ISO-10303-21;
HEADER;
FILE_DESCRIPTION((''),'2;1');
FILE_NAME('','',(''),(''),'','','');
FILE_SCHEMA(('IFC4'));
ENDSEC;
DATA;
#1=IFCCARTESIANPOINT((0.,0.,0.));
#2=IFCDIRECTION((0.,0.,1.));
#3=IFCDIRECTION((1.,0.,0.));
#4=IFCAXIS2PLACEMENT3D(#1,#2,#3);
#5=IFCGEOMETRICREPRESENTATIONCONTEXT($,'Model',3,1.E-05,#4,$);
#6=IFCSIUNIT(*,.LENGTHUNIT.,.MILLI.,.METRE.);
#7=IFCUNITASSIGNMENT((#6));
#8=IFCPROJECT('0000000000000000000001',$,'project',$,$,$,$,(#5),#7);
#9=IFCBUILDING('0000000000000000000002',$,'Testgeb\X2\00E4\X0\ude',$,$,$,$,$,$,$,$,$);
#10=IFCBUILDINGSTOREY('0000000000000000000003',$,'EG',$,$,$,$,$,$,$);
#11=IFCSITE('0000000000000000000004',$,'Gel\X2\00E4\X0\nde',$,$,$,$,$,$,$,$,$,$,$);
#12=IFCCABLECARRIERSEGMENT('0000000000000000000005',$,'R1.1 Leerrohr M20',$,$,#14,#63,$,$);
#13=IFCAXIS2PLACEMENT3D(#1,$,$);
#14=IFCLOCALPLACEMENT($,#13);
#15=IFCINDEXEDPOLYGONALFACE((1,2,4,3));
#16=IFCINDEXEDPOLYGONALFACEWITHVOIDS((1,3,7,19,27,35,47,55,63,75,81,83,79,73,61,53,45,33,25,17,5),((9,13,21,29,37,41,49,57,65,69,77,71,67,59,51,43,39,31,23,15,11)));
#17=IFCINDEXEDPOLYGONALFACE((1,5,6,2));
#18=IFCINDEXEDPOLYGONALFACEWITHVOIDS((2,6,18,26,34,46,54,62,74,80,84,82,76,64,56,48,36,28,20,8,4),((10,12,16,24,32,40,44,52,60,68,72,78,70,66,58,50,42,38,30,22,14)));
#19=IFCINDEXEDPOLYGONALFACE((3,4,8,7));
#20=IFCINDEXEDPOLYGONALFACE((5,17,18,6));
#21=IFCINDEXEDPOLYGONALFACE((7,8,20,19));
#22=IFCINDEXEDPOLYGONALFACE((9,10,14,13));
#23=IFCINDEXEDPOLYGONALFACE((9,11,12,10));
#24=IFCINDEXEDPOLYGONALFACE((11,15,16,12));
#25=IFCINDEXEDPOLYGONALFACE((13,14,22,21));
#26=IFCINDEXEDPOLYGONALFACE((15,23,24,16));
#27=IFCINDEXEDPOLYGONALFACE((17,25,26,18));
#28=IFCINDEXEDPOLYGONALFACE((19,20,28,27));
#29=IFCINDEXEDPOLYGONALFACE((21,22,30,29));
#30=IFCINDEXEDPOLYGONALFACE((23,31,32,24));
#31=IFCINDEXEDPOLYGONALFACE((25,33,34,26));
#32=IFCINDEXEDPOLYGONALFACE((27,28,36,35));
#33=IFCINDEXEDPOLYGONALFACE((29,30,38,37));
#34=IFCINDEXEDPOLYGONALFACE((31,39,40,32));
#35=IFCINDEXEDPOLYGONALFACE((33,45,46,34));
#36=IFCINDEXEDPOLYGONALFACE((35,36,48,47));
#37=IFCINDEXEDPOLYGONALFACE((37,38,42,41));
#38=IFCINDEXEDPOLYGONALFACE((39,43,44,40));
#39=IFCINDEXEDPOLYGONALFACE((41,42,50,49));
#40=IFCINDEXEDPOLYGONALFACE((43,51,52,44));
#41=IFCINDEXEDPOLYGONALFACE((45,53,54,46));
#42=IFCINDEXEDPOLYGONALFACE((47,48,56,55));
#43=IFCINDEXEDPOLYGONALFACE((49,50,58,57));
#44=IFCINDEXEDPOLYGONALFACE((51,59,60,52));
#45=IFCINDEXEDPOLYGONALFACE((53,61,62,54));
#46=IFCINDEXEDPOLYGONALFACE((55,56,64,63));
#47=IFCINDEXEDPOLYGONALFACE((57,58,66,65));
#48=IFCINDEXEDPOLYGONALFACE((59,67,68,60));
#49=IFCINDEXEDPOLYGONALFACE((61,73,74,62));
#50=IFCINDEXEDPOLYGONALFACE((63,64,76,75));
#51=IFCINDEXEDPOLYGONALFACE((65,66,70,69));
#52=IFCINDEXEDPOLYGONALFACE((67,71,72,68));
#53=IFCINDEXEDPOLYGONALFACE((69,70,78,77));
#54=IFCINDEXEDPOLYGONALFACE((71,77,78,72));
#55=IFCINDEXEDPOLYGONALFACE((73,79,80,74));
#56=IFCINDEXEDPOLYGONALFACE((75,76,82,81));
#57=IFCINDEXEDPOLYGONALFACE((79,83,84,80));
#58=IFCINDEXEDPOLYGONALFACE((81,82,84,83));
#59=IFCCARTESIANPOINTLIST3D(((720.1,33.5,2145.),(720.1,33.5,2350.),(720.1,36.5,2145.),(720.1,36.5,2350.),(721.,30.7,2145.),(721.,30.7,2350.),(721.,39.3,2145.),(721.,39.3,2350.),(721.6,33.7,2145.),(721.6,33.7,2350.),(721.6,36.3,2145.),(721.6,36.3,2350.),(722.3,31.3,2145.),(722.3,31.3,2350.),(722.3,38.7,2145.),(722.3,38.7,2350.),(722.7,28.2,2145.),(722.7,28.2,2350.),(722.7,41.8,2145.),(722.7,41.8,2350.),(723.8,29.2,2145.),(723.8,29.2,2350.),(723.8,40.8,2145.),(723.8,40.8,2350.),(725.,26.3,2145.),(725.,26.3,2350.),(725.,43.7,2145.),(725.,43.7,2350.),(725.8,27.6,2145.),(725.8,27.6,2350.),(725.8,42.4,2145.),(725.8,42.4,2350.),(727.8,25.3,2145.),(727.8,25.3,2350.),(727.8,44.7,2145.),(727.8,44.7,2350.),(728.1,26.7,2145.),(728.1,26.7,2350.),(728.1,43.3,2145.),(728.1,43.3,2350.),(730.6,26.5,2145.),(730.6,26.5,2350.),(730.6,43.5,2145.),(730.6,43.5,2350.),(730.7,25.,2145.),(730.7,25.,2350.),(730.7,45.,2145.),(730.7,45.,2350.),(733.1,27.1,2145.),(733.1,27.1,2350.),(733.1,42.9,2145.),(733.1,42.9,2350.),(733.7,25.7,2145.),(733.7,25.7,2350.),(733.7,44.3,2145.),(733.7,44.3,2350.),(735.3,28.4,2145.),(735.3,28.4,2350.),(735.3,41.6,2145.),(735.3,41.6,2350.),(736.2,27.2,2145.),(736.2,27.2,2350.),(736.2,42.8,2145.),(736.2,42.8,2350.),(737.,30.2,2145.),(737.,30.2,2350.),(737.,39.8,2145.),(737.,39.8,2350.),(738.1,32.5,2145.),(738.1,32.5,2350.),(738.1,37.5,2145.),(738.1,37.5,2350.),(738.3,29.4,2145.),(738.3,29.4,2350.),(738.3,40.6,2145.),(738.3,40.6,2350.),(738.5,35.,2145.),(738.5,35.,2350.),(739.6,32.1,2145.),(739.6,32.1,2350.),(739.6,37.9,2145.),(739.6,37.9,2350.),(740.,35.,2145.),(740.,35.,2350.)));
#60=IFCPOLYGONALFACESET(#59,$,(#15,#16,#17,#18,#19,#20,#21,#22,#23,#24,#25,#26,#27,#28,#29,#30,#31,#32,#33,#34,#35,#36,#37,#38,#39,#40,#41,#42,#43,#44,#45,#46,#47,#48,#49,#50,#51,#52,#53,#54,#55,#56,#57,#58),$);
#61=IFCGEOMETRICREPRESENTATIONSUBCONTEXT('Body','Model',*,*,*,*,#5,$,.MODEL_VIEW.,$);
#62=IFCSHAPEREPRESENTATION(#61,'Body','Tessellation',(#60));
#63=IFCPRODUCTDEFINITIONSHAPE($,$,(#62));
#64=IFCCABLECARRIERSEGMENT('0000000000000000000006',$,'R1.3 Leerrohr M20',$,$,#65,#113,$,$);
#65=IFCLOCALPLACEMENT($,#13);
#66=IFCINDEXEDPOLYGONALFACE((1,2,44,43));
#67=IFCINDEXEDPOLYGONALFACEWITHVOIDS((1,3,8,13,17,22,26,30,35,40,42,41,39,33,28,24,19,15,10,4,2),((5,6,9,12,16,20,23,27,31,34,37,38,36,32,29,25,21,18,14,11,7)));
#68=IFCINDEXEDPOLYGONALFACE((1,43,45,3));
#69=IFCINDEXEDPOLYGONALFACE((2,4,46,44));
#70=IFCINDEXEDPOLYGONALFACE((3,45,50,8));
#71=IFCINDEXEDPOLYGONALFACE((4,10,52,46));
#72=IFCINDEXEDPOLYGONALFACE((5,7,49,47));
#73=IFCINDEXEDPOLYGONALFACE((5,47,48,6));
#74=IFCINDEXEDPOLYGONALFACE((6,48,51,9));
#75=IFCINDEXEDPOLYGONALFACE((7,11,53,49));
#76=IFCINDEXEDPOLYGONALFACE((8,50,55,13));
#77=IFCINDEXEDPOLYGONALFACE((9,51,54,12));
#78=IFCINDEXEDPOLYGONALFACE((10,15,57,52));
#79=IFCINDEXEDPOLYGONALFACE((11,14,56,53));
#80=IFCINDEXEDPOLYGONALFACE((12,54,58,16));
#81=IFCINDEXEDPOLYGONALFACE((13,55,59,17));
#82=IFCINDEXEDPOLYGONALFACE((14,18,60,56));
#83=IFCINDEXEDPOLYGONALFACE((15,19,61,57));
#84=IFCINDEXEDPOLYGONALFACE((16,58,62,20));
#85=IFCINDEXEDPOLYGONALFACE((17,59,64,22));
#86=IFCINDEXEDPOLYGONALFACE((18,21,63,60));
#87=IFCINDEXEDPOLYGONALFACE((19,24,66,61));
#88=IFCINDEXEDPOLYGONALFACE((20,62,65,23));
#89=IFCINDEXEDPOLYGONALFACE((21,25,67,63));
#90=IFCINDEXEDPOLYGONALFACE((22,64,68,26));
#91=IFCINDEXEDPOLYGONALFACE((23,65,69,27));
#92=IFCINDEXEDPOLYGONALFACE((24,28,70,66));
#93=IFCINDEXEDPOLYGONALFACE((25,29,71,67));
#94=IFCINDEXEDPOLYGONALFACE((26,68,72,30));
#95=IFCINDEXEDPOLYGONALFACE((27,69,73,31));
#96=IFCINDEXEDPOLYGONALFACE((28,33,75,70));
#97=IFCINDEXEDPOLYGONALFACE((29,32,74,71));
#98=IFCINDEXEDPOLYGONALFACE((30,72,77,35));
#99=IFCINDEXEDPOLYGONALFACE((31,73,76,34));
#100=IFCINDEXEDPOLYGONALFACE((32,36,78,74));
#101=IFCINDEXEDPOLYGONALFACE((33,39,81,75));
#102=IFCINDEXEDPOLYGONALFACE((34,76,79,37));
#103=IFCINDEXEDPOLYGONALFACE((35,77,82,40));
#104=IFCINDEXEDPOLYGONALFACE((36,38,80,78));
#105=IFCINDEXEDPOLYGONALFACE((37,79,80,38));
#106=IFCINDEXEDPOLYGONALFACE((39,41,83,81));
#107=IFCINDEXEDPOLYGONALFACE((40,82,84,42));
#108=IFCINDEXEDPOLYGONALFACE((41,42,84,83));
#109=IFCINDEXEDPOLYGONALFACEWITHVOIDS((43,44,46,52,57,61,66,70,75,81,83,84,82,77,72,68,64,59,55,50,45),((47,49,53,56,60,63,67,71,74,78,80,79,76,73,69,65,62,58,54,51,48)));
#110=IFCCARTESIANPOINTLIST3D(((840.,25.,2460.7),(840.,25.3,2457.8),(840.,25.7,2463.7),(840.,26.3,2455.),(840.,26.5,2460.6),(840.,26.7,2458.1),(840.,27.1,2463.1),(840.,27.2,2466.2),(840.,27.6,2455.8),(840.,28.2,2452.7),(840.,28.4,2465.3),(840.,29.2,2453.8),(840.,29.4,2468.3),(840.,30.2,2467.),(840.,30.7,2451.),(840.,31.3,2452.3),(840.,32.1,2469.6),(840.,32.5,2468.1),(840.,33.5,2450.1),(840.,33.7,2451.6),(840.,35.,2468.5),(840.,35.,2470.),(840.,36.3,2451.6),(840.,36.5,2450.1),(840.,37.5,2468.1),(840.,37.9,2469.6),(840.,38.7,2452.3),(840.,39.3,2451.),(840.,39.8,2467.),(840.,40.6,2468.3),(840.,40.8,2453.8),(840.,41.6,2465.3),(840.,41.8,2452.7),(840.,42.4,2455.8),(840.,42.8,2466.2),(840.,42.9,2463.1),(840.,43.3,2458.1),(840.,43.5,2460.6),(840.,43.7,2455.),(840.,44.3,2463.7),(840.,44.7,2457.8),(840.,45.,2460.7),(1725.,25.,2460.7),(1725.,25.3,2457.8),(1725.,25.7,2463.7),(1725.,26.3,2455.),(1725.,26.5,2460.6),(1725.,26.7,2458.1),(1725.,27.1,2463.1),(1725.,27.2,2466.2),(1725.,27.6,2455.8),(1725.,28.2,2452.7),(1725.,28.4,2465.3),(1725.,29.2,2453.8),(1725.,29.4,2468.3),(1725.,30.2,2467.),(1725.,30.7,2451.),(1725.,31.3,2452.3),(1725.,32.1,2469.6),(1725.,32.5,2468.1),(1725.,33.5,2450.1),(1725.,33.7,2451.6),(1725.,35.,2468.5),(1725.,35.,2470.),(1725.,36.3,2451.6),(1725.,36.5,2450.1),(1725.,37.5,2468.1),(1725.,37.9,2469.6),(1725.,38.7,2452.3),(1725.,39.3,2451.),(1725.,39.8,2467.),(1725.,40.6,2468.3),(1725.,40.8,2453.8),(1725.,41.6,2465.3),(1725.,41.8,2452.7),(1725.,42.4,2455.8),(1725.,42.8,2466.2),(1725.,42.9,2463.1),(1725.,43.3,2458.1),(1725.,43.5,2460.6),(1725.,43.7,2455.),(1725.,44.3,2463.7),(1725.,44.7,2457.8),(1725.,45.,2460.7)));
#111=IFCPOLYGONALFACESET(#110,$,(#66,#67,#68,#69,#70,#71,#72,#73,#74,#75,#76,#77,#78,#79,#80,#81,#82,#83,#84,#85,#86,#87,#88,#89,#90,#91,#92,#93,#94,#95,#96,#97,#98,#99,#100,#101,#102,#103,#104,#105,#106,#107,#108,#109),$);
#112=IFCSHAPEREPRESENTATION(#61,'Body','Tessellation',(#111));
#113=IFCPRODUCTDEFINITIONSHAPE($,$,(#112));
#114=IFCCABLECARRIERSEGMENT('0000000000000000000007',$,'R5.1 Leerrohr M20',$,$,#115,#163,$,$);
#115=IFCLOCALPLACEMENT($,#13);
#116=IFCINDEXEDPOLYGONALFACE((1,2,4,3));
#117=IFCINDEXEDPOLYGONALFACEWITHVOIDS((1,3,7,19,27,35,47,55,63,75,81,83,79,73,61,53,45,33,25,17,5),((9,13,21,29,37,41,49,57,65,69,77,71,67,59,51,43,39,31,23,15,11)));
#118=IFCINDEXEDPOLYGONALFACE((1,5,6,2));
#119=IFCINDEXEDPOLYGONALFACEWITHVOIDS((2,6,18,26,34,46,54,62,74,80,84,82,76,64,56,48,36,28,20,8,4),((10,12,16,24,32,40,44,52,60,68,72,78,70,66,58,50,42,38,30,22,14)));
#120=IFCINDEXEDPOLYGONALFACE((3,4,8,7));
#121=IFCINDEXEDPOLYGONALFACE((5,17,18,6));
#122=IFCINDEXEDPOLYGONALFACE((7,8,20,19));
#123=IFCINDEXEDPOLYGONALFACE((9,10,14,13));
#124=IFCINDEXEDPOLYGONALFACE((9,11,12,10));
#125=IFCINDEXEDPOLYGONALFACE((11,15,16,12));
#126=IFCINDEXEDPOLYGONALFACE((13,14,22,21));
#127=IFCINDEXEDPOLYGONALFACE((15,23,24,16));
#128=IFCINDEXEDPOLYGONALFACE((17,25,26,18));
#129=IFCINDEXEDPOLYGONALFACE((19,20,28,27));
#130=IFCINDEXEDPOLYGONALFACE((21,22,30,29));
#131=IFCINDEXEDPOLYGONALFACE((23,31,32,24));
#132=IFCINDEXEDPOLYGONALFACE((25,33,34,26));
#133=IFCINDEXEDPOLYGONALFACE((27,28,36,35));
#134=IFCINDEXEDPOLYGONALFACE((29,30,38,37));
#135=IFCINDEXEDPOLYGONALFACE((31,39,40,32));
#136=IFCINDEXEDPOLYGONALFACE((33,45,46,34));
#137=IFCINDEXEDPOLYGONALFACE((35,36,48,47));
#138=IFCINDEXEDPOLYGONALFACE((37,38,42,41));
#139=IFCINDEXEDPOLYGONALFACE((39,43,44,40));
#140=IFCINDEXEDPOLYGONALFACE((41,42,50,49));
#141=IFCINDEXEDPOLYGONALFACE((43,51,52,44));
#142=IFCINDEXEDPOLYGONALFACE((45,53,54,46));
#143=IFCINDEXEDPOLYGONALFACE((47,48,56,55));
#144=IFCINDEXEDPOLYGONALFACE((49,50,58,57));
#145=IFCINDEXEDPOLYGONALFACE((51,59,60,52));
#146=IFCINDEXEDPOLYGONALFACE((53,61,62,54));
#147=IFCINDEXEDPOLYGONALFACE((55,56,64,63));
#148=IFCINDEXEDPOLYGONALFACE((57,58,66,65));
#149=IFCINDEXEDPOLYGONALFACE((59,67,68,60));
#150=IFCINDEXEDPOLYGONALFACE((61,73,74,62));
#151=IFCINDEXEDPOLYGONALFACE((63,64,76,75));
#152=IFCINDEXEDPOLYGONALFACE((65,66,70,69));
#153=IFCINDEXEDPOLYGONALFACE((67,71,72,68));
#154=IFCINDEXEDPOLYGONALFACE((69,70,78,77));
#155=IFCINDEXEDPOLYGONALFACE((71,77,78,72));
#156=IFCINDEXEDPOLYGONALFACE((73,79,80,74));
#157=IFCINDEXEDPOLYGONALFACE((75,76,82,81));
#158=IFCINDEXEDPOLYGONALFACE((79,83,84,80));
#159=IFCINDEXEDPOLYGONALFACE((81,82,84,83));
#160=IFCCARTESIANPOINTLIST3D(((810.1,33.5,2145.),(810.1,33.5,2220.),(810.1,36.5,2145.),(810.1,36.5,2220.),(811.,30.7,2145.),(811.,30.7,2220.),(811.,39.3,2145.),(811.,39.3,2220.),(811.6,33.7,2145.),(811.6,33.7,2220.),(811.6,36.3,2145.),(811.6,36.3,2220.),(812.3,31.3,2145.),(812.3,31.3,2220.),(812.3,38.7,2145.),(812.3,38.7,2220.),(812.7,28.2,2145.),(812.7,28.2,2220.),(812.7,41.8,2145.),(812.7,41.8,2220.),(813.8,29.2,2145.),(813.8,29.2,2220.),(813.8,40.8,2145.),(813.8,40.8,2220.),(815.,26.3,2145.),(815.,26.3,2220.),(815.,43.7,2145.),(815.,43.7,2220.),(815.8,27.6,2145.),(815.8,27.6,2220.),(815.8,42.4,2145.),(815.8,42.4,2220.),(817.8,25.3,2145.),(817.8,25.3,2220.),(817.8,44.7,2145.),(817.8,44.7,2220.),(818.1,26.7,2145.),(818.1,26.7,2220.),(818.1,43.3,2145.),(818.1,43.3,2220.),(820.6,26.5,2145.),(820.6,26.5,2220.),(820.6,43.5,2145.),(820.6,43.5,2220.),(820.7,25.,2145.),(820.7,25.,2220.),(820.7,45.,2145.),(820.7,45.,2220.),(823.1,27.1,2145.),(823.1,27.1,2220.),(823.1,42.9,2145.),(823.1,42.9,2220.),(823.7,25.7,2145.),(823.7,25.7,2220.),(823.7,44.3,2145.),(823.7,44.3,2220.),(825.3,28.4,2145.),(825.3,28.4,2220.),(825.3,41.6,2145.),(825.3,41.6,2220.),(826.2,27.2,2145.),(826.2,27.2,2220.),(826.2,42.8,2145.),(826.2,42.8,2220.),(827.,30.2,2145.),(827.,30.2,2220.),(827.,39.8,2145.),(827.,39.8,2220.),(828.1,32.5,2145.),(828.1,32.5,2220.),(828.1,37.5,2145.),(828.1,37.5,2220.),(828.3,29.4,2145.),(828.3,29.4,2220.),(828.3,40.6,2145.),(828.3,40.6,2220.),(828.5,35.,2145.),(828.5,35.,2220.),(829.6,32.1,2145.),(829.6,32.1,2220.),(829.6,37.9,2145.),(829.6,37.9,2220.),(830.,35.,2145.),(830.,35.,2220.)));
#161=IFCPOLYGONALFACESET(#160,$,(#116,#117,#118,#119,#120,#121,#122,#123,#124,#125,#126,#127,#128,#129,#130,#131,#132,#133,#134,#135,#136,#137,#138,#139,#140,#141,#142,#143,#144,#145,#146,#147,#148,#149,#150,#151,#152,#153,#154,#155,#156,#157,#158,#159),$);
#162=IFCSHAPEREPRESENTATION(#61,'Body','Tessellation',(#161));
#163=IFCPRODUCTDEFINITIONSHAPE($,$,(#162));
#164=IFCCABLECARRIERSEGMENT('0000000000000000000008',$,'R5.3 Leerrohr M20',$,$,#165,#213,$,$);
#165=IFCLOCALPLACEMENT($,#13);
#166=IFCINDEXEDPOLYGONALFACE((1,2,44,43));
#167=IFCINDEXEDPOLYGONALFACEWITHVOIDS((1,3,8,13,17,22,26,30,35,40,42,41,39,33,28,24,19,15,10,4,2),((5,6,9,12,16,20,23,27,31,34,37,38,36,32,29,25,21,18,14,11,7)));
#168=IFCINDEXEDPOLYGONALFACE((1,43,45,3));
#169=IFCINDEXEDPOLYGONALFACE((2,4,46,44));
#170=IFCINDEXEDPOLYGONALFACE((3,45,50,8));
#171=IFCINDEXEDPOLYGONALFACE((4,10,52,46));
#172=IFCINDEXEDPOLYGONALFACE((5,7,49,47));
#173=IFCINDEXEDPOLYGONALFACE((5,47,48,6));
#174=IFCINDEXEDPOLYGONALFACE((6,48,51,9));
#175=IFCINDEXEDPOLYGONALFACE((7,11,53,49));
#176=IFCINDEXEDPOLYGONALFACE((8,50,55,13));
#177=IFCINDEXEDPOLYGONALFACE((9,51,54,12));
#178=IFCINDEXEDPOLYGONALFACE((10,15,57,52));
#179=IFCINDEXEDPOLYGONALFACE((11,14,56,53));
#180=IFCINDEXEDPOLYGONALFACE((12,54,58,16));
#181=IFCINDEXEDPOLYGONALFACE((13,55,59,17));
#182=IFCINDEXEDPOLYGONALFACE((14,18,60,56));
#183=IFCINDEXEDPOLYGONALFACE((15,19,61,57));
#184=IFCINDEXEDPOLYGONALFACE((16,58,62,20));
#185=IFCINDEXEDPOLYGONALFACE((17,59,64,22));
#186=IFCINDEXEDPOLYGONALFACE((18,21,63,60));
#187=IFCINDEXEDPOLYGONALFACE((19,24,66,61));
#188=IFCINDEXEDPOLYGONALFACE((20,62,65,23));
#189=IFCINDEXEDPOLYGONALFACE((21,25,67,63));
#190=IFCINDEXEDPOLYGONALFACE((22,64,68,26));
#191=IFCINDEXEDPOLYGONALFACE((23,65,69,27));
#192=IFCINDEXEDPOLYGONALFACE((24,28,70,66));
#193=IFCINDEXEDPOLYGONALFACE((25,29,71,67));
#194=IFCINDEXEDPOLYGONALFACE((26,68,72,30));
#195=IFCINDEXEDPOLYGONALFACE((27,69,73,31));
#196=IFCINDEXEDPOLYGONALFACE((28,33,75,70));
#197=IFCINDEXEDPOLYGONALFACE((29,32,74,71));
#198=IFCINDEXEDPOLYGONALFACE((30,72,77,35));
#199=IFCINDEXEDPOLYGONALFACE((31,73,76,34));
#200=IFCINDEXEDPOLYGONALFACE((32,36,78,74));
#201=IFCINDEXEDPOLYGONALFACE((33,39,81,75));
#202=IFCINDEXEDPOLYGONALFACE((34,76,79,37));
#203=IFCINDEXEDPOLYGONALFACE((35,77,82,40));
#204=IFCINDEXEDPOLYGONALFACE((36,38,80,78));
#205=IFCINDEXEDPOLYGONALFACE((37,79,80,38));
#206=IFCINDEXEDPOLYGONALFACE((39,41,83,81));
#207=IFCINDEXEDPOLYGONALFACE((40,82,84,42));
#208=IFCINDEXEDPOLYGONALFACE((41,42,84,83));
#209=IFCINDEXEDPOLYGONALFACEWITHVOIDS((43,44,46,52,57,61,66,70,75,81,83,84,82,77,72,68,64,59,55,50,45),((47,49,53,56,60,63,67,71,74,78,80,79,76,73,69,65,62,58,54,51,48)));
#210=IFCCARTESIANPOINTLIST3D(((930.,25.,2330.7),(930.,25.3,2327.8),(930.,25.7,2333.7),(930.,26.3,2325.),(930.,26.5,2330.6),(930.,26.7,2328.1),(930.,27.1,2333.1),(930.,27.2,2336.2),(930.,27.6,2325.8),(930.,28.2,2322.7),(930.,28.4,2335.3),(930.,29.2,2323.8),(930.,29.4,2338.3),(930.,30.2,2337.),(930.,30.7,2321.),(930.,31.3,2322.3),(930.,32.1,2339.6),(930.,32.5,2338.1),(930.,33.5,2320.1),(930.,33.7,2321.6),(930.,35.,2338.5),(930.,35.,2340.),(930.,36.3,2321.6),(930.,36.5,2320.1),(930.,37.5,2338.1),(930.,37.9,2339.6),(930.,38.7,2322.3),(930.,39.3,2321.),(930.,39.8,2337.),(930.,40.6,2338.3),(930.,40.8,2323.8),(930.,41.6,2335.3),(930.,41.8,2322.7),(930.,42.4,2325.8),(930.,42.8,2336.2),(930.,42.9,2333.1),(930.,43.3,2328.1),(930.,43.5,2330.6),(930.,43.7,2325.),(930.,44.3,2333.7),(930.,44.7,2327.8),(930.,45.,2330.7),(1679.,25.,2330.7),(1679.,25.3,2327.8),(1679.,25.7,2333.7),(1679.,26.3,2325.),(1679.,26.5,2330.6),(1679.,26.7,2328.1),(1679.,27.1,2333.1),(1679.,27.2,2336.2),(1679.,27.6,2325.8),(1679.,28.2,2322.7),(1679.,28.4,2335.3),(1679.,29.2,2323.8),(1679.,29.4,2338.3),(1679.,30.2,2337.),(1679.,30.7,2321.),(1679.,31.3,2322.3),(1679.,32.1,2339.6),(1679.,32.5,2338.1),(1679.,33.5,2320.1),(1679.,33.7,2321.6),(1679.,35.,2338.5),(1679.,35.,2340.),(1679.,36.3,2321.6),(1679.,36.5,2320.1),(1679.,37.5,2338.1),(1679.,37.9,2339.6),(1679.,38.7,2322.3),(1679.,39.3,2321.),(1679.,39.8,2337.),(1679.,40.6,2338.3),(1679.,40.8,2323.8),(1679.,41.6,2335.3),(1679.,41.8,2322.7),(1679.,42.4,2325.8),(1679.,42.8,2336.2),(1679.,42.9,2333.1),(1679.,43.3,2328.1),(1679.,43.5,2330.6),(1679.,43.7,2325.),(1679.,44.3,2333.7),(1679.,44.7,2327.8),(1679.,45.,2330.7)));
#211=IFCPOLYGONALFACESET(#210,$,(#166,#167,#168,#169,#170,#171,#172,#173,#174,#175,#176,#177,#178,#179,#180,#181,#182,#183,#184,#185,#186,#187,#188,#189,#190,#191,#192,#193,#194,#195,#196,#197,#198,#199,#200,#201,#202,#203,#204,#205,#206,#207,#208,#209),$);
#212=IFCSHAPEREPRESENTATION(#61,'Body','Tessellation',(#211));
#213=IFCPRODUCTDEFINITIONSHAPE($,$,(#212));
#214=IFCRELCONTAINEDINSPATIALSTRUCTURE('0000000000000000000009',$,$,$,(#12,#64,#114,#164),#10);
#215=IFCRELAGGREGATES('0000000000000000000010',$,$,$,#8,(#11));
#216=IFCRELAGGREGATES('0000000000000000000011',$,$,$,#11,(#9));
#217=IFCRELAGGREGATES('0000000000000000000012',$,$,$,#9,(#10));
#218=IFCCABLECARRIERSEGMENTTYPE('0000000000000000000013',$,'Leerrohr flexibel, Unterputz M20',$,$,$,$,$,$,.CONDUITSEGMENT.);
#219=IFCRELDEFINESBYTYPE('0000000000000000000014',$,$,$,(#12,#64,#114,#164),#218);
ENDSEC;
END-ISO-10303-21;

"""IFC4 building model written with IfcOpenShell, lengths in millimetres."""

from ifc_helpers import new_model, si_unit, frame, origin_with_axes, place, context, subcontext, project, spatial, hollow_circle, extrude, type_object, element, save


model = new_model("IFC4")

# Units and contexts
model_context = context("Model", 3, precision=1e-05, world=origin_with_axes())
body_context = subcontext(model_context, "Body", "Model", "MODEL_VIEW")
ifc_project = project(units=[si_unit("LENGTHUNIT", "METRE", prefix="MILLI")], contexts=[model_context])

# Site, building, storey
site = spatial("IfcSite", under=ifc_project, Name="Gelände")
building = spatial("IfcBuilding", under=site, Name="Testgebäude")
storey = spatial("IfcBuildingStorey", under=building, Name="EG")

# Cable carrier segments
cable_carrier_segment_type_1 = type_object("IfcCableCarrierSegmentType", Name="Leerrohr flexibel, Unterputz M20", PredefinedType="CONDUITSEGMENT")
cable_carrier_segment_1_placement = place(None, frame((730.0, 35.0, 2145.0), z_axis=(0.0, 0.0, 1.0), x_axis=(1.0, 0.0, 0.0)))
element("IfcCableCarrierSegment", 1, at=cable_carrier_segment_1_placement, inside=storey, type_object=cable_carrier_segment_type_1, Name="R1.1 Leerrohr M20", context=body_context, shape_type="SweptSolid", body=[
    extrude(hollow_circle(Radius=10.0, WallThickness=1.5), None, (0.0, 0.0, 1.0), 205.0),
])
cable_carrier_segment_2_placement = place(None, frame((840.0, 35.0, 2460.0), z_axis=(1.0, 0.0, 0.0), x_axis=(0.0, 0.0, 1.0)))
element("IfcCableCarrierSegment", 2, at=cable_carrier_segment_2_placement, inside=storey, type_object=cable_carrier_segment_type_1, Name="R1.3 Leerrohr M20", context=body_context, shape_type="SweptSolid", body=[
    extrude(hollow_circle(Radius=10.0, WallThickness=1.5), None, (0.0, 0.0, 1.0), 885.0),
])
cable_carrier_segment_3_placement = place(None, frame((820.0, 35.0, 2145.0), z_axis=(0.0, 0.0, 1.0), x_axis=(1.0, 0.0, 0.0)))
element("IfcCableCarrierSegment", 3, at=cable_carrier_segment_3_placement, inside=storey, type_object=cable_carrier_segment_type_1, Name="R5.1 Leerrohr M20", context=body_context, shape_type="SweptSolid", body=[
    extrude(hollow_circle(Radius=10.0, WallThickness=1.5), None, (0.0, 0.0, 1.0), 75.0),
])
cable_carrier_segment_4_placement = place(None, frame((930.0, 35.0, 2330.0), z_axis=(1.0, 0.0, 0.0), x_axis=(0.0, 0.0, 1.0)))
element("IfcCableCarrierSegment", 4, at=cable_carrier_segment_4_placement, inside=storey, type_object=cable_carrier_segment_type_1, Name="R5.3 Leerrohr M20", context=body_context, shape_type="SweptSolid", body=[
    extrude(hollow_circle(Radius=10.0, WallThickness=1.5), None, (0.0, 0.0, 1.0), 749.0),
])

save(model, "model.ifc")
